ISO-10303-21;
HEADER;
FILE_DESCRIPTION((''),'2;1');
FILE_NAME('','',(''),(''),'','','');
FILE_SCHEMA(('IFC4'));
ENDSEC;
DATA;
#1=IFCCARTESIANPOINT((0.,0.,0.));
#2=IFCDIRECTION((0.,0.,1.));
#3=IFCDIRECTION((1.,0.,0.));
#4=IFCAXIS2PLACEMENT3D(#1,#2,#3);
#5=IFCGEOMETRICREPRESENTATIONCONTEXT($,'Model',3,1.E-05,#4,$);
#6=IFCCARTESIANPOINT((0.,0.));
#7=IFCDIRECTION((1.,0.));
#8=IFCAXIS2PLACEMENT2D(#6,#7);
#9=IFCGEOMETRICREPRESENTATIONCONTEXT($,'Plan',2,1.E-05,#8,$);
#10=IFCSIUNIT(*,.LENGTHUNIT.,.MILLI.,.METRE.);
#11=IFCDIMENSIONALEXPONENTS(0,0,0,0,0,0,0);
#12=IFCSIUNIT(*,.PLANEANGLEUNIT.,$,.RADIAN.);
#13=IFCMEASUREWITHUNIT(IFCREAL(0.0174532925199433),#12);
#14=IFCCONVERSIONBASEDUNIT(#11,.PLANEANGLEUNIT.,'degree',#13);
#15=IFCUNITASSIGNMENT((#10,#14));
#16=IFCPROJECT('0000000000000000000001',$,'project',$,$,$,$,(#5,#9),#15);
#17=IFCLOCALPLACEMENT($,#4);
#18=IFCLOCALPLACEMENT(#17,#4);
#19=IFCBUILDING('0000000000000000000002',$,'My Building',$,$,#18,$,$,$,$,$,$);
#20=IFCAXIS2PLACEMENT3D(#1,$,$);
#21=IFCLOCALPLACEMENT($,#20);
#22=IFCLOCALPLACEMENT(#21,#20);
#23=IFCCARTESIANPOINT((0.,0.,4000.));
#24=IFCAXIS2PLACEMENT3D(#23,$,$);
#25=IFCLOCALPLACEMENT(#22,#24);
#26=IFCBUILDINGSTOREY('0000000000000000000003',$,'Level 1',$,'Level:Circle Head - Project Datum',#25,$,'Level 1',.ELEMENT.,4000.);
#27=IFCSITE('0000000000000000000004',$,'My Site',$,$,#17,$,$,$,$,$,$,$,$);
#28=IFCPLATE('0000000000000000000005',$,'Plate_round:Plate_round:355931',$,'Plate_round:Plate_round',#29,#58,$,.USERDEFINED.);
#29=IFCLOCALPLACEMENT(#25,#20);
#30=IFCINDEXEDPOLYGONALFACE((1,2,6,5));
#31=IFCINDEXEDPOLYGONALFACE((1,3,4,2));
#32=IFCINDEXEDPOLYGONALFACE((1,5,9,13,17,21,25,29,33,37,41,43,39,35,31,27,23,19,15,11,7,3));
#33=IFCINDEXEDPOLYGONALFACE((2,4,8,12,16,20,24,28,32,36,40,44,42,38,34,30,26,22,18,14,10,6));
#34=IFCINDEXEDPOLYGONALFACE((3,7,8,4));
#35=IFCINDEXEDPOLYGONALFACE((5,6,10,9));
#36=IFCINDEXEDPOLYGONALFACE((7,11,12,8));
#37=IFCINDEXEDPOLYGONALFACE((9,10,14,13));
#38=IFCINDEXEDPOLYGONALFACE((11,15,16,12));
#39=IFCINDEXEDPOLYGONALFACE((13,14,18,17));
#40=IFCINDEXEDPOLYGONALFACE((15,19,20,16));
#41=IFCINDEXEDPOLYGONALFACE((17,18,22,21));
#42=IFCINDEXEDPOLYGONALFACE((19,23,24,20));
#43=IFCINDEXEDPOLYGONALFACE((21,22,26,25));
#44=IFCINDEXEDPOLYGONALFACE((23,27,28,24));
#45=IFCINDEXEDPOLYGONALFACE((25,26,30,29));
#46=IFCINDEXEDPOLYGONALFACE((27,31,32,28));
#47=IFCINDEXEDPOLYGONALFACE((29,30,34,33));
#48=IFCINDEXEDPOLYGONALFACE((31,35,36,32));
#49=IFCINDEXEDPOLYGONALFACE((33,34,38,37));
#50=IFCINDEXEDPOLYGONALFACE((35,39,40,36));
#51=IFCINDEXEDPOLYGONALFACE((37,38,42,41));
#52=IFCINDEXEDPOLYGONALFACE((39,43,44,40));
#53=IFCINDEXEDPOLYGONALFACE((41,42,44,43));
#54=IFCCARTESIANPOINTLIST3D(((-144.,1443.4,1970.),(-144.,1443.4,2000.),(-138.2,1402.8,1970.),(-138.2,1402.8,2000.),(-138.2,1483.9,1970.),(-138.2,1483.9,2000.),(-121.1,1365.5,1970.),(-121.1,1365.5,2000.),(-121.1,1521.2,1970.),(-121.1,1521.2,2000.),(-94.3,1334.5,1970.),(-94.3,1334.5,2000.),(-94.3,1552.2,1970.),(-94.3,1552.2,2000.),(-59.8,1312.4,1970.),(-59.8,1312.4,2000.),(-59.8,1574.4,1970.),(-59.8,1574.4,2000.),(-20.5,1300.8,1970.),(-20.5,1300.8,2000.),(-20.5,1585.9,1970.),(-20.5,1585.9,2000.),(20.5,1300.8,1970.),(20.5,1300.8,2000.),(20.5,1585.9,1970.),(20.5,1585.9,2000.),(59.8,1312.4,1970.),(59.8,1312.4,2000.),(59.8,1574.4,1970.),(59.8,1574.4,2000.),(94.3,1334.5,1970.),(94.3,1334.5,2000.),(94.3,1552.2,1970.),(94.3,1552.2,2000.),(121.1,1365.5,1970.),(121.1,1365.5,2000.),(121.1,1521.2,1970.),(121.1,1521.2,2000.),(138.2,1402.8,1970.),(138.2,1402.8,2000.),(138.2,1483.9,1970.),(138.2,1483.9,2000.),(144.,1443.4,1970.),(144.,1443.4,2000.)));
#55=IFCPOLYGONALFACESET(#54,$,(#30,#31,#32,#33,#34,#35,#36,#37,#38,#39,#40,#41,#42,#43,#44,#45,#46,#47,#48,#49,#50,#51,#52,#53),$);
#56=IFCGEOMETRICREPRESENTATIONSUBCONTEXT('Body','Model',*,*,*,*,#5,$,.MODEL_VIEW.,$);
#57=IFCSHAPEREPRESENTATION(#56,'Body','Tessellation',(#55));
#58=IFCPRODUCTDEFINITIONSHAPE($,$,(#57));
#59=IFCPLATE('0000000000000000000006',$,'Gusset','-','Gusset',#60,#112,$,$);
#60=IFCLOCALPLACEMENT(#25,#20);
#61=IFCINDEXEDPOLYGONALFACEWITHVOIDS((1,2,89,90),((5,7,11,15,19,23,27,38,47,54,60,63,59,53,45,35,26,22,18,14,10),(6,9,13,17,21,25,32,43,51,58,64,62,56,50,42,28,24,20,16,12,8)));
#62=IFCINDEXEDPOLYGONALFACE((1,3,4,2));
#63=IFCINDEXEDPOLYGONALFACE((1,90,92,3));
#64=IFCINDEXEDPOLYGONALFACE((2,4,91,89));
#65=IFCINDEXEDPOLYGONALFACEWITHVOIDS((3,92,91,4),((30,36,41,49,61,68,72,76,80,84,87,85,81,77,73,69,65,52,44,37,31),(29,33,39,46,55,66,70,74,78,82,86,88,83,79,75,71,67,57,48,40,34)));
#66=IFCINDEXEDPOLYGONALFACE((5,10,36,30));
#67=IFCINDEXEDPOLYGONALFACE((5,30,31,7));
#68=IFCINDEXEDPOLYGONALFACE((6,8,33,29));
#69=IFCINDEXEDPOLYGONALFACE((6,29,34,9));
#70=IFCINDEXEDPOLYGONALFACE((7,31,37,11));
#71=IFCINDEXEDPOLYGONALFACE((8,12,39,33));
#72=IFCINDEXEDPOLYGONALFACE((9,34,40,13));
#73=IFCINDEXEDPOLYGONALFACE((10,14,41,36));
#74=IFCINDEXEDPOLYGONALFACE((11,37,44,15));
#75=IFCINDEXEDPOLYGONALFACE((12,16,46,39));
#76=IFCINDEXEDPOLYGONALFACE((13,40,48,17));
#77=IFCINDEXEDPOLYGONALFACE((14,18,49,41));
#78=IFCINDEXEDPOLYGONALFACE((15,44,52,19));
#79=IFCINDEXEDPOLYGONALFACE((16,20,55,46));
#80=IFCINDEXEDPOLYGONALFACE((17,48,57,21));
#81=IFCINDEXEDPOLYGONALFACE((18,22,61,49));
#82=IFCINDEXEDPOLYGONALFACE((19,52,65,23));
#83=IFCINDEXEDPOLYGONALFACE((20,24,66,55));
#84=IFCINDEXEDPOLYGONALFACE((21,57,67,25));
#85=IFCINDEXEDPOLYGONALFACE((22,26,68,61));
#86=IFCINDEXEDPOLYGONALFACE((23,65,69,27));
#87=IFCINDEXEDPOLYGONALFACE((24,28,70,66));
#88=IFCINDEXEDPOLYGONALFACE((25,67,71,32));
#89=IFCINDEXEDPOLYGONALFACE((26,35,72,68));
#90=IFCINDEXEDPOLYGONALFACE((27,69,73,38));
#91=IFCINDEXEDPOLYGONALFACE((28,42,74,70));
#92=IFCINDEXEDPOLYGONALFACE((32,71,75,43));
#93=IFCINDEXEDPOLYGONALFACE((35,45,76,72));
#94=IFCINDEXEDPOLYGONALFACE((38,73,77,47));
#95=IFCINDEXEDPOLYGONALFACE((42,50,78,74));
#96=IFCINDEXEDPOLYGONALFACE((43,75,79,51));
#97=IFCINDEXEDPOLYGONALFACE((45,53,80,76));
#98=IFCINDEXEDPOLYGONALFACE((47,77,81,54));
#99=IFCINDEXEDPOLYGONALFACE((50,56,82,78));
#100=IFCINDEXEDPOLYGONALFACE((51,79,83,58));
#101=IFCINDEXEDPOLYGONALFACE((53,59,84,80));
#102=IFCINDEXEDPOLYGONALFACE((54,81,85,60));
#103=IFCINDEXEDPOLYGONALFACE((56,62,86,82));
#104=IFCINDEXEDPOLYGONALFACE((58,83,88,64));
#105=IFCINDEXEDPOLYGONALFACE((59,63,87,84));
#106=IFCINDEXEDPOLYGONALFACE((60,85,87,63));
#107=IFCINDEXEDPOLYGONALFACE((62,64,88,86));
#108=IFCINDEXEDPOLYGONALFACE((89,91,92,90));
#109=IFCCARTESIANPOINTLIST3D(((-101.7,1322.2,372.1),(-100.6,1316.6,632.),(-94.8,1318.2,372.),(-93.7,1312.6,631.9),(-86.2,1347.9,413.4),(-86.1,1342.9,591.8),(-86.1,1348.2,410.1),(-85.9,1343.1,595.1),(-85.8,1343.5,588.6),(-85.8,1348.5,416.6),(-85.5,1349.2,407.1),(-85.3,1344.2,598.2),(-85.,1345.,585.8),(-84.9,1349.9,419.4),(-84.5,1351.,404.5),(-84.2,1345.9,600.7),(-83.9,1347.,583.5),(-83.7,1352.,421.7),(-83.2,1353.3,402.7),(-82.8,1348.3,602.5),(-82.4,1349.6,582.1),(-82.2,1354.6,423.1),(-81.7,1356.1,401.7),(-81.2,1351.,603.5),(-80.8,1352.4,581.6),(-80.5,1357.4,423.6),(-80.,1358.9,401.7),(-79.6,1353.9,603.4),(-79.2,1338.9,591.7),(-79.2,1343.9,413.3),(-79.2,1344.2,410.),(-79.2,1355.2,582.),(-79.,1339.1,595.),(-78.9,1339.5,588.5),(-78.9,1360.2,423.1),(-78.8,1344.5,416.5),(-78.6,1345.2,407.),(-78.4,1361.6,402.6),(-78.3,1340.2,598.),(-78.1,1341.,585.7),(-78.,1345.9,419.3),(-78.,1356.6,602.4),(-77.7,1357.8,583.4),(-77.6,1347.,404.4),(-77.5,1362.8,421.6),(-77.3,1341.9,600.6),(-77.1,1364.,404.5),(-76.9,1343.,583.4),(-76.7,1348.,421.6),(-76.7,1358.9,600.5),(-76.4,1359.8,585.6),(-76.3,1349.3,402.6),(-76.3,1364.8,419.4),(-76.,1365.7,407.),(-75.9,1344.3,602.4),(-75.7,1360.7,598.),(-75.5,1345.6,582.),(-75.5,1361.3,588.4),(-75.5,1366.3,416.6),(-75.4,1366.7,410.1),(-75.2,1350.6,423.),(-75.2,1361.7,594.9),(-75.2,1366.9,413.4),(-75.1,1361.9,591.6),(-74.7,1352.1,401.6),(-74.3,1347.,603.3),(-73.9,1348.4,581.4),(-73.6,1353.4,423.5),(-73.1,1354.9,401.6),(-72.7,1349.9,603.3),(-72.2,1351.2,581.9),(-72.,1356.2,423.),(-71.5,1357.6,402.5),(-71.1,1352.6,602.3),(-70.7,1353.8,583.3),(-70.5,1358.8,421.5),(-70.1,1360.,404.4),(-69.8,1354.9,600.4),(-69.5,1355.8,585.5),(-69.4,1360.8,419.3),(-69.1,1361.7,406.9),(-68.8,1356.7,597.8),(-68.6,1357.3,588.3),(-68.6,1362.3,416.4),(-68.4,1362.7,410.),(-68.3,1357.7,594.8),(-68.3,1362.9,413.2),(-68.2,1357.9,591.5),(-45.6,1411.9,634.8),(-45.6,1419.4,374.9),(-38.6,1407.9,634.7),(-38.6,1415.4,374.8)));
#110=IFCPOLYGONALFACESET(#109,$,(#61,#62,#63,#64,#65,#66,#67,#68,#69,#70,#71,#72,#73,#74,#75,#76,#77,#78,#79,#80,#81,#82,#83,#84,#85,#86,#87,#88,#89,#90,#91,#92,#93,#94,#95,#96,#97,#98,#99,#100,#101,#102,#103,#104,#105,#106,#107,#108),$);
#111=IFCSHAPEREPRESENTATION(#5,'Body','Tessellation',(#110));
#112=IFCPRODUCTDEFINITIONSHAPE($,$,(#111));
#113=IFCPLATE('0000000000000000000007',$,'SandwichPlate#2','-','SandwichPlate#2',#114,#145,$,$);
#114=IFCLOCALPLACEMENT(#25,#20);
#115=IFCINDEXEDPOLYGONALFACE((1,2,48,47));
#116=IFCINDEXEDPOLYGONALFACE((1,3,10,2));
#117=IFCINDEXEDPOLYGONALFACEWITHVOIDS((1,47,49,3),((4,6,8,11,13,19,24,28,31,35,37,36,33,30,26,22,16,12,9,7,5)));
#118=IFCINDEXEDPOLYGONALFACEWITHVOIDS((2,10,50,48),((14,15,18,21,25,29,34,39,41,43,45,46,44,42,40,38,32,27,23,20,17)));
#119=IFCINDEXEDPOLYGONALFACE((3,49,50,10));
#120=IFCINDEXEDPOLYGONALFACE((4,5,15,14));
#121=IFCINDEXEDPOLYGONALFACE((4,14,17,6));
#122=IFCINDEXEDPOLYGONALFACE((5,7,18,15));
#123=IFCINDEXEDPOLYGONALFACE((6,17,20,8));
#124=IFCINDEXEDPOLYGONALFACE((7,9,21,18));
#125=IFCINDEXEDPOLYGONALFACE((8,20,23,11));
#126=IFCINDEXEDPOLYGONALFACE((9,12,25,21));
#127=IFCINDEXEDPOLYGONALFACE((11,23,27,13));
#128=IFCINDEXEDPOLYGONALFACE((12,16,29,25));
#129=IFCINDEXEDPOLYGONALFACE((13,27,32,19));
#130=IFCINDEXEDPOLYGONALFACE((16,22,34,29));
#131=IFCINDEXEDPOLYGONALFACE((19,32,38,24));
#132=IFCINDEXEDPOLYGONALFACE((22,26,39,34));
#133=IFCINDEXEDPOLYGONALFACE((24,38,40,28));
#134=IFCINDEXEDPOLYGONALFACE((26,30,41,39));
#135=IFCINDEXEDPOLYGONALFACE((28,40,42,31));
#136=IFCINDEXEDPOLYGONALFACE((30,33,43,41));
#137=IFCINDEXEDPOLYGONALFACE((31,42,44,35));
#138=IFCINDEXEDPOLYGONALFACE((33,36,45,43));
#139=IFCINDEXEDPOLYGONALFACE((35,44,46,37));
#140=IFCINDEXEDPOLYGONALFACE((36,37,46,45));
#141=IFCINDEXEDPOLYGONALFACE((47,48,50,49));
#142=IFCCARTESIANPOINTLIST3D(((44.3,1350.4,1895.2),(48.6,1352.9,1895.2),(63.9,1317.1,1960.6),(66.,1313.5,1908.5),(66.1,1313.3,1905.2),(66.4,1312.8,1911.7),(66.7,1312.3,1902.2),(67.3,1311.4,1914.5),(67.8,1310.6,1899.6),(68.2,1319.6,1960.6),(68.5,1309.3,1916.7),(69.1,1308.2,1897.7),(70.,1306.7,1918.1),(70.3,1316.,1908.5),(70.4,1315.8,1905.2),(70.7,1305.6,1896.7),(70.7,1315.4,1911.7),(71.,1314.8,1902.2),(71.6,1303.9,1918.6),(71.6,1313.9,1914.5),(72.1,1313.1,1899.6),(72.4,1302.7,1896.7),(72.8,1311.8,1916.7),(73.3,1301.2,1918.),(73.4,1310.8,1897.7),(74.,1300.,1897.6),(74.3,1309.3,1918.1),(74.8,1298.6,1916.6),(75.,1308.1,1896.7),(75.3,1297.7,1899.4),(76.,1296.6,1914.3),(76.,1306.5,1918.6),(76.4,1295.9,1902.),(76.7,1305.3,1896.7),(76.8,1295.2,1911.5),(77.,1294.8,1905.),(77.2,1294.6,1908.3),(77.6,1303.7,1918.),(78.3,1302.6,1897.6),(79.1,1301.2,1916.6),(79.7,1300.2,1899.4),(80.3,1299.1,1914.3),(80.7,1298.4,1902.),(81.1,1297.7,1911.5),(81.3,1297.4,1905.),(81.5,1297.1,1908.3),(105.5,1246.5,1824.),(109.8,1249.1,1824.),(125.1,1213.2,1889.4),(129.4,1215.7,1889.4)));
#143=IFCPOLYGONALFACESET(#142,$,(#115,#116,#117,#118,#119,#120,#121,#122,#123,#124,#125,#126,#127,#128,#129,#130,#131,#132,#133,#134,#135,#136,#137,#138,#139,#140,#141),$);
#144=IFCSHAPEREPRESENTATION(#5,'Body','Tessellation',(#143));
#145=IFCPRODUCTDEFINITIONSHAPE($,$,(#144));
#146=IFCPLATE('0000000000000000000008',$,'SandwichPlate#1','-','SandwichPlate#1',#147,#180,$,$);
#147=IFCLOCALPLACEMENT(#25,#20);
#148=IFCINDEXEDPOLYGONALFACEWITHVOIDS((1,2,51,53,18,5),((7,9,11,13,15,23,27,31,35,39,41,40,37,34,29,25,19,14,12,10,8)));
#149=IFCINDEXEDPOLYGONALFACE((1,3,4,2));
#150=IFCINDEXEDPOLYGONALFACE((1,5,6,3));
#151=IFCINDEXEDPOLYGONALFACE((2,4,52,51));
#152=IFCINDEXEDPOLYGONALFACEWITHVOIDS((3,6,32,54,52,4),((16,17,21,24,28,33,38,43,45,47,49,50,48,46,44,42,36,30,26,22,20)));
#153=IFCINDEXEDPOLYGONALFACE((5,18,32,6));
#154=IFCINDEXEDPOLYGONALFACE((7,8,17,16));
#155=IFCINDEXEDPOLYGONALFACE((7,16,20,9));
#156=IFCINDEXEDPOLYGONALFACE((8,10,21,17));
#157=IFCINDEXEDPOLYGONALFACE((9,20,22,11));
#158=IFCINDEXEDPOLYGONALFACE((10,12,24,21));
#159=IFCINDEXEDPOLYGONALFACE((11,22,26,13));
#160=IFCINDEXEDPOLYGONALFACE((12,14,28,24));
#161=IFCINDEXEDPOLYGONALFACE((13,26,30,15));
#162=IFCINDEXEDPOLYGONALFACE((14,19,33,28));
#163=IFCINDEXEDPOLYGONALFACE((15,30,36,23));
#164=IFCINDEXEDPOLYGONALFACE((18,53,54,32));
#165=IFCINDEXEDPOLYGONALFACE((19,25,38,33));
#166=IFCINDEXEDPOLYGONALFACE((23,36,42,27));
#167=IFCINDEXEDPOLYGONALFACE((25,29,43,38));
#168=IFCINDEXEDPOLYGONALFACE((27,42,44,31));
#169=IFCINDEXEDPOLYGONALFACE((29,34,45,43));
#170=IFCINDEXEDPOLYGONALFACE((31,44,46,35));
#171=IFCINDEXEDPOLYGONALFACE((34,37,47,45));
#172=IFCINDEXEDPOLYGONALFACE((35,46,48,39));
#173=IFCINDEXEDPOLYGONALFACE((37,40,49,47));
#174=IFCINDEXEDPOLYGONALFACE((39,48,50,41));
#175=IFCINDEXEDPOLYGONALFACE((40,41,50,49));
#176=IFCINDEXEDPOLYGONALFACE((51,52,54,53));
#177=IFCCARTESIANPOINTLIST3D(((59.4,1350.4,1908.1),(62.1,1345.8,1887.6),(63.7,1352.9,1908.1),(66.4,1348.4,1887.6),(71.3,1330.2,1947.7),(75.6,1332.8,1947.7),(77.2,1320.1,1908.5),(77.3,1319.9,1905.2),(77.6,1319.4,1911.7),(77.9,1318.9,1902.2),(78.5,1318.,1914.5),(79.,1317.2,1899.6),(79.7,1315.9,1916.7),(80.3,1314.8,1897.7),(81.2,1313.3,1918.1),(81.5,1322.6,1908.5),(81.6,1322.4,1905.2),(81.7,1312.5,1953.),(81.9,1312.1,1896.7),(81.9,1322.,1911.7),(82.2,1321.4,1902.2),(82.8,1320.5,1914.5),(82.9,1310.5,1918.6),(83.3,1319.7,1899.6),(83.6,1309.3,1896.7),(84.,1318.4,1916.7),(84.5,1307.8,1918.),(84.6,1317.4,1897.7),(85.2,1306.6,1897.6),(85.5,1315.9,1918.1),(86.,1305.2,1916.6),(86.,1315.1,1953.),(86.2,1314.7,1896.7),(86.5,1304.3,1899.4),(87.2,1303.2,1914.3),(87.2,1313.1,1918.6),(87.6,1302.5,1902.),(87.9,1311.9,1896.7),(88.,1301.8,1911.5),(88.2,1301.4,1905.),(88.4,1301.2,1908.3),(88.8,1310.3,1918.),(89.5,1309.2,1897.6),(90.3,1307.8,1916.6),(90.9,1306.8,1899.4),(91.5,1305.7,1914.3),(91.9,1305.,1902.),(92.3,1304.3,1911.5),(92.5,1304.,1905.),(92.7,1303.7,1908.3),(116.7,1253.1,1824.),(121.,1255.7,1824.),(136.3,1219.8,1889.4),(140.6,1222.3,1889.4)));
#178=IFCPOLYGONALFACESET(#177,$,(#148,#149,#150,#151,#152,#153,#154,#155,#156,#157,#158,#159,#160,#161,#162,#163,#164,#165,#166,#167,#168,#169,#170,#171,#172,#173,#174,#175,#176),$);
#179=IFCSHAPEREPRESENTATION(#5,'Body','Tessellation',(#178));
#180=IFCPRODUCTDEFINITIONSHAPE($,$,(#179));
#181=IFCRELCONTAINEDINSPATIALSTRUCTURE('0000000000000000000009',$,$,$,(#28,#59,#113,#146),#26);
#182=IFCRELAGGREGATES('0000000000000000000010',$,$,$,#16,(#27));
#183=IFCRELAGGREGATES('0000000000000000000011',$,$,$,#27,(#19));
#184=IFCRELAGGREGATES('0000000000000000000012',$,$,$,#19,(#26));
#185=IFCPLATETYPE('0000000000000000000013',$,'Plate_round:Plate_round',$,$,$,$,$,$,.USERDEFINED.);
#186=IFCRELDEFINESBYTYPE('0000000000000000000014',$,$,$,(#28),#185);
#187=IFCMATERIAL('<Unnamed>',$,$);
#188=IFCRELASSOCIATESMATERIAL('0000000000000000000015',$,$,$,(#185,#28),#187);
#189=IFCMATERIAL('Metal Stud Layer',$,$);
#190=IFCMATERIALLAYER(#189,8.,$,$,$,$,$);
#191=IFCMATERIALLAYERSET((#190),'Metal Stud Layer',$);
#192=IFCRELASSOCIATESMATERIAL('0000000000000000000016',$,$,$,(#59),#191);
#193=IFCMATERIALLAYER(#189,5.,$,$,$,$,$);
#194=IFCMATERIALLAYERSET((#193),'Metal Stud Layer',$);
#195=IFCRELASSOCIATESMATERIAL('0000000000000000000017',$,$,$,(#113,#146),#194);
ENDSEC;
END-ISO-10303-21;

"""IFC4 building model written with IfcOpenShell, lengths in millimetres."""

from ifc_helpers import new_model, entity, si_unit, converted_unit, frame, origin, origin_with_axes, origin_2d_with_axis, place, context, subcontext, project, spatial, polyline, arc, indexed_curve, circle, outline, extrude, source, transform, mapped, material, layer, layer_set, type_object, type_shapes, element, save


model = new_model("IFC4")

# Units and contexts
model_context = context("Model", 3, precision=1e-05, world=origin_with_axes())
plan_context = context("Plan", 2, precision=1e-05, world=origin_2d_with_axis())
body_context = subcontext(model_context, "Body", "Model", "MODEL_VIEW")
ifc_project = project(units=[si_unit("LENGTHUNIT", "METRE", prefix="MILLI"), converted_unit("PLANEANGLEUNIT", "degree", entity("IfcReal", 0.0174532925199433), si_unit("PLANEANGLEUNIT", "RADIAN"), dimensions=[0, 0, 0, 0, 0, 0, 0])], contexts=[model_context, plan_context])

# Site, building, storey
site_placement = place(None, origin_with_axes())
site = spatial("IfcSite", under=ifc_project, at=site_placement, Name="My Site")
building_placement = place(site_placement, origin_with_axes())
building = spatial("IfcBuilding", under=site, at=building_placement, Name="My Building")
placement_1 = place(None, origin())
placement_2 = place(placement_1, origin())
storey_placement = place(placement_2, frame((0.0, 0.0, 4000.0)))
storey = spatial("IfcBuildingStorey", under=building, at=storey_placement, Name="Level 1", ObjectType="Level:Circle Head - Project Datum", LongName="Level 1", CompositionType="ELEMENT", Elevation=4000.0)

# Plate
ifc_material_1 = material(Name="<Unnamed>")
plate_type = type_object("IfcPlateType", Name="Plate_round:Plate_round", PredefinedType="USERDEFINED", material=ifc_material_1)
shared_shape = source(origin(), body_context, "Body", "SweptSolid", [
    extrude(outline(indexed_curve([(-144.0, 0.0), (0.0, -144.0), (144.0, 0.0), (0.0, 144.0)], segments=[arc(1, 2, 3), arc(3, 4, 1)], self_intersect=False)), origin(), (0.0, 0.0, 1.0), 30.0),
])
type_shapes(plate_type, [shared_shape])
plate_1_placement = place(storey_placement, frame((0.0, 1443.4, 1970.0)))
element("IfcPlate", 1, at=plate_1_placement, inside=storey, type_object=plate_type, material=ifc_material_1, Name="Plate_round:Plate_round:355931", ObjectType="Plate_round:Plate_round", PredefinedType="USERDEFINED", context=body_context, shape_type="MappedRepresentation", body=[
    mapped(shared_shape, transform((0.0, 0.0, 0.0), scale=1.0)),
])

# Plate, openings
ifc_material_2 = material(Name="Metal Stud Layer")
ifc_layer_1 = layer(ifc_material_2, 8.0)
ifc_layer_set_1 = layer_set([ifc_layer_1], Name="Metal Stud Layer")
plate_2_placement = place(storey_placement, frame((-39.8, 1405.9, 634.8), z_axis=(-0.865935, 0.499948, 0.014432), x_axis=(0.0, 0.028855, -0.999584)))
plate_2 = element("IfcPlate", 2, at=plate_2_placement, inside=storey, material=ifc_layer_set_1, Name="Gusset", Description="-", ObjectType="Gusset", context=model_context, shape_type="SweptSolid", body=[
    extrude(outline(polyline([(0.2, -2.3), (260.2, -2.3), (260.2, 110.0), (0.2, 107.8), (0.2, -2.3)])), origin_with_axes(), (0.0, 0.0, 1.0), 8.0),
])
opening_1_placement = place(plate_2_placement, frame((40.7, 67.8, 8.5), z_axis=(0.0, 0.0, -1.0), x_axis=(-0.530279, 0.847823, 0.0)))
element("IfcOpeningElement", 3, at=opening_1_placement, cuts=plate_2, ObjectType="Opening", context=model_context, shape_type="SweptSolid", body=[
    extrude(circle(Radius=11.0, at=origin_2d_with_axis()), origin(), (0.0, 0.0, 1.0), 9.0),
])
opening_2_placement = place(plate_2_placement, frame((220.8, 68.0, 8.5), z_axis=(0.0, 0.0, -1.0), x_axis=(0.47613, 0.879375, 0.0)))
element("IfcOpeningElement", 4, at=opening_2_placement, cuts=plate_2, ObjectType="Opening", context=model_context, shape_type="SweptSolid", body=[
    extrude(circle(Radius=11.0, at=origin_2d_with_axis()), origin(), (0.0, 0.0, 1.0), 9.0),
])

# Plates, openings
ifc_layer_2 = layer(ifc_material_2, 5.0)
ifc_layer_set_2 = layer_set([ifc_layer_2], Name="Metal Stud Layer")
plate_3_placement = place(storey_placement, frame((68.2, 1319.6, 1960.6), z_axis=(-0.861728, -0.507371, 0.0), x_axis=(-0.258184, 0.438505, -0.860845)))
plate_3 = element("IfcPlate", 5, at=plate_3_placement, inside=storey, material=ifc_layer_set_2, Name="SandwichPlate#2", Description="-", ObjectType="SandwichPlate#2", context=model_context, shape_type="SweptSolid", body=[
    extrude(outline(polyline([(0.0, 0.0), (76.0, 0.0), (76.0, 140.0), (0.0, 140.0), (0.0, 0.0)])), origin_with_axes(), (0.0, 0.0, 1.0), 5.0),
])
opening_3_placement = place(plate_3_placement, frame((38.0, 40.0, -0.5), z_axis=(0.0, 0.0, 1.0), x_axis=(0.0, 1.0, 0.0)))
element("IfcOpeningElement", 6, at=opening_3_placement, cuts=plate_3, ObjectType="Opening", context=model_context, shape_type="SweptSolid", body=[
    extrude(circle(Radius=11.0, at=origin_2d_with_axis()), origin(), (0.0, 0.0, 1.0), 6.0),
])
plate_4_placement = place(storey_placement, frame((79.4, 1326.2, 1960.6), z_axis=(-0.861728, -0.507371, 0.0), x_axis=(-0.258184, 0.438505, -0.860845)))
plate_4 = element("IfcPlate", 7, at=plate_4_placement, inside=storey, material=ifc_layer_set_2, Name="SandwichPlate#1", Description="-", ObjectType="SandwichPlate#1", context=model_context, shape_type="SweptSolid", body=[
    extrude(outline(polyline([(15.0, 0.0), (61.0, 0.0), (76.0, 15.0), (76.0, 140.0), (0.0, 140.0), (0.0, 15.0), (15.0, 0.0)])), origin_with_axes(), (0.0, 0.0, 1.0), 5.0),
])
opening_4_placement = place(plate_4_placement, frame((38.0, 40.0, -0.5), z_axis=(0.0, 0.0, 1.0), x_axis=(0.0, 1.0, 0.0)))
element("IfcOpeningElement", 8, at=opening_4_placement, cuts=plate_4, ObjectType="Opening", context=model_context, shape_type="SweptSolid", body=[
    extrude(circle(Radius=11.0, at=origin_2d_with_axis()), origin(), (0.0, 0.0, 1.0), 6.0),
])

save(model, "model.ifc")
